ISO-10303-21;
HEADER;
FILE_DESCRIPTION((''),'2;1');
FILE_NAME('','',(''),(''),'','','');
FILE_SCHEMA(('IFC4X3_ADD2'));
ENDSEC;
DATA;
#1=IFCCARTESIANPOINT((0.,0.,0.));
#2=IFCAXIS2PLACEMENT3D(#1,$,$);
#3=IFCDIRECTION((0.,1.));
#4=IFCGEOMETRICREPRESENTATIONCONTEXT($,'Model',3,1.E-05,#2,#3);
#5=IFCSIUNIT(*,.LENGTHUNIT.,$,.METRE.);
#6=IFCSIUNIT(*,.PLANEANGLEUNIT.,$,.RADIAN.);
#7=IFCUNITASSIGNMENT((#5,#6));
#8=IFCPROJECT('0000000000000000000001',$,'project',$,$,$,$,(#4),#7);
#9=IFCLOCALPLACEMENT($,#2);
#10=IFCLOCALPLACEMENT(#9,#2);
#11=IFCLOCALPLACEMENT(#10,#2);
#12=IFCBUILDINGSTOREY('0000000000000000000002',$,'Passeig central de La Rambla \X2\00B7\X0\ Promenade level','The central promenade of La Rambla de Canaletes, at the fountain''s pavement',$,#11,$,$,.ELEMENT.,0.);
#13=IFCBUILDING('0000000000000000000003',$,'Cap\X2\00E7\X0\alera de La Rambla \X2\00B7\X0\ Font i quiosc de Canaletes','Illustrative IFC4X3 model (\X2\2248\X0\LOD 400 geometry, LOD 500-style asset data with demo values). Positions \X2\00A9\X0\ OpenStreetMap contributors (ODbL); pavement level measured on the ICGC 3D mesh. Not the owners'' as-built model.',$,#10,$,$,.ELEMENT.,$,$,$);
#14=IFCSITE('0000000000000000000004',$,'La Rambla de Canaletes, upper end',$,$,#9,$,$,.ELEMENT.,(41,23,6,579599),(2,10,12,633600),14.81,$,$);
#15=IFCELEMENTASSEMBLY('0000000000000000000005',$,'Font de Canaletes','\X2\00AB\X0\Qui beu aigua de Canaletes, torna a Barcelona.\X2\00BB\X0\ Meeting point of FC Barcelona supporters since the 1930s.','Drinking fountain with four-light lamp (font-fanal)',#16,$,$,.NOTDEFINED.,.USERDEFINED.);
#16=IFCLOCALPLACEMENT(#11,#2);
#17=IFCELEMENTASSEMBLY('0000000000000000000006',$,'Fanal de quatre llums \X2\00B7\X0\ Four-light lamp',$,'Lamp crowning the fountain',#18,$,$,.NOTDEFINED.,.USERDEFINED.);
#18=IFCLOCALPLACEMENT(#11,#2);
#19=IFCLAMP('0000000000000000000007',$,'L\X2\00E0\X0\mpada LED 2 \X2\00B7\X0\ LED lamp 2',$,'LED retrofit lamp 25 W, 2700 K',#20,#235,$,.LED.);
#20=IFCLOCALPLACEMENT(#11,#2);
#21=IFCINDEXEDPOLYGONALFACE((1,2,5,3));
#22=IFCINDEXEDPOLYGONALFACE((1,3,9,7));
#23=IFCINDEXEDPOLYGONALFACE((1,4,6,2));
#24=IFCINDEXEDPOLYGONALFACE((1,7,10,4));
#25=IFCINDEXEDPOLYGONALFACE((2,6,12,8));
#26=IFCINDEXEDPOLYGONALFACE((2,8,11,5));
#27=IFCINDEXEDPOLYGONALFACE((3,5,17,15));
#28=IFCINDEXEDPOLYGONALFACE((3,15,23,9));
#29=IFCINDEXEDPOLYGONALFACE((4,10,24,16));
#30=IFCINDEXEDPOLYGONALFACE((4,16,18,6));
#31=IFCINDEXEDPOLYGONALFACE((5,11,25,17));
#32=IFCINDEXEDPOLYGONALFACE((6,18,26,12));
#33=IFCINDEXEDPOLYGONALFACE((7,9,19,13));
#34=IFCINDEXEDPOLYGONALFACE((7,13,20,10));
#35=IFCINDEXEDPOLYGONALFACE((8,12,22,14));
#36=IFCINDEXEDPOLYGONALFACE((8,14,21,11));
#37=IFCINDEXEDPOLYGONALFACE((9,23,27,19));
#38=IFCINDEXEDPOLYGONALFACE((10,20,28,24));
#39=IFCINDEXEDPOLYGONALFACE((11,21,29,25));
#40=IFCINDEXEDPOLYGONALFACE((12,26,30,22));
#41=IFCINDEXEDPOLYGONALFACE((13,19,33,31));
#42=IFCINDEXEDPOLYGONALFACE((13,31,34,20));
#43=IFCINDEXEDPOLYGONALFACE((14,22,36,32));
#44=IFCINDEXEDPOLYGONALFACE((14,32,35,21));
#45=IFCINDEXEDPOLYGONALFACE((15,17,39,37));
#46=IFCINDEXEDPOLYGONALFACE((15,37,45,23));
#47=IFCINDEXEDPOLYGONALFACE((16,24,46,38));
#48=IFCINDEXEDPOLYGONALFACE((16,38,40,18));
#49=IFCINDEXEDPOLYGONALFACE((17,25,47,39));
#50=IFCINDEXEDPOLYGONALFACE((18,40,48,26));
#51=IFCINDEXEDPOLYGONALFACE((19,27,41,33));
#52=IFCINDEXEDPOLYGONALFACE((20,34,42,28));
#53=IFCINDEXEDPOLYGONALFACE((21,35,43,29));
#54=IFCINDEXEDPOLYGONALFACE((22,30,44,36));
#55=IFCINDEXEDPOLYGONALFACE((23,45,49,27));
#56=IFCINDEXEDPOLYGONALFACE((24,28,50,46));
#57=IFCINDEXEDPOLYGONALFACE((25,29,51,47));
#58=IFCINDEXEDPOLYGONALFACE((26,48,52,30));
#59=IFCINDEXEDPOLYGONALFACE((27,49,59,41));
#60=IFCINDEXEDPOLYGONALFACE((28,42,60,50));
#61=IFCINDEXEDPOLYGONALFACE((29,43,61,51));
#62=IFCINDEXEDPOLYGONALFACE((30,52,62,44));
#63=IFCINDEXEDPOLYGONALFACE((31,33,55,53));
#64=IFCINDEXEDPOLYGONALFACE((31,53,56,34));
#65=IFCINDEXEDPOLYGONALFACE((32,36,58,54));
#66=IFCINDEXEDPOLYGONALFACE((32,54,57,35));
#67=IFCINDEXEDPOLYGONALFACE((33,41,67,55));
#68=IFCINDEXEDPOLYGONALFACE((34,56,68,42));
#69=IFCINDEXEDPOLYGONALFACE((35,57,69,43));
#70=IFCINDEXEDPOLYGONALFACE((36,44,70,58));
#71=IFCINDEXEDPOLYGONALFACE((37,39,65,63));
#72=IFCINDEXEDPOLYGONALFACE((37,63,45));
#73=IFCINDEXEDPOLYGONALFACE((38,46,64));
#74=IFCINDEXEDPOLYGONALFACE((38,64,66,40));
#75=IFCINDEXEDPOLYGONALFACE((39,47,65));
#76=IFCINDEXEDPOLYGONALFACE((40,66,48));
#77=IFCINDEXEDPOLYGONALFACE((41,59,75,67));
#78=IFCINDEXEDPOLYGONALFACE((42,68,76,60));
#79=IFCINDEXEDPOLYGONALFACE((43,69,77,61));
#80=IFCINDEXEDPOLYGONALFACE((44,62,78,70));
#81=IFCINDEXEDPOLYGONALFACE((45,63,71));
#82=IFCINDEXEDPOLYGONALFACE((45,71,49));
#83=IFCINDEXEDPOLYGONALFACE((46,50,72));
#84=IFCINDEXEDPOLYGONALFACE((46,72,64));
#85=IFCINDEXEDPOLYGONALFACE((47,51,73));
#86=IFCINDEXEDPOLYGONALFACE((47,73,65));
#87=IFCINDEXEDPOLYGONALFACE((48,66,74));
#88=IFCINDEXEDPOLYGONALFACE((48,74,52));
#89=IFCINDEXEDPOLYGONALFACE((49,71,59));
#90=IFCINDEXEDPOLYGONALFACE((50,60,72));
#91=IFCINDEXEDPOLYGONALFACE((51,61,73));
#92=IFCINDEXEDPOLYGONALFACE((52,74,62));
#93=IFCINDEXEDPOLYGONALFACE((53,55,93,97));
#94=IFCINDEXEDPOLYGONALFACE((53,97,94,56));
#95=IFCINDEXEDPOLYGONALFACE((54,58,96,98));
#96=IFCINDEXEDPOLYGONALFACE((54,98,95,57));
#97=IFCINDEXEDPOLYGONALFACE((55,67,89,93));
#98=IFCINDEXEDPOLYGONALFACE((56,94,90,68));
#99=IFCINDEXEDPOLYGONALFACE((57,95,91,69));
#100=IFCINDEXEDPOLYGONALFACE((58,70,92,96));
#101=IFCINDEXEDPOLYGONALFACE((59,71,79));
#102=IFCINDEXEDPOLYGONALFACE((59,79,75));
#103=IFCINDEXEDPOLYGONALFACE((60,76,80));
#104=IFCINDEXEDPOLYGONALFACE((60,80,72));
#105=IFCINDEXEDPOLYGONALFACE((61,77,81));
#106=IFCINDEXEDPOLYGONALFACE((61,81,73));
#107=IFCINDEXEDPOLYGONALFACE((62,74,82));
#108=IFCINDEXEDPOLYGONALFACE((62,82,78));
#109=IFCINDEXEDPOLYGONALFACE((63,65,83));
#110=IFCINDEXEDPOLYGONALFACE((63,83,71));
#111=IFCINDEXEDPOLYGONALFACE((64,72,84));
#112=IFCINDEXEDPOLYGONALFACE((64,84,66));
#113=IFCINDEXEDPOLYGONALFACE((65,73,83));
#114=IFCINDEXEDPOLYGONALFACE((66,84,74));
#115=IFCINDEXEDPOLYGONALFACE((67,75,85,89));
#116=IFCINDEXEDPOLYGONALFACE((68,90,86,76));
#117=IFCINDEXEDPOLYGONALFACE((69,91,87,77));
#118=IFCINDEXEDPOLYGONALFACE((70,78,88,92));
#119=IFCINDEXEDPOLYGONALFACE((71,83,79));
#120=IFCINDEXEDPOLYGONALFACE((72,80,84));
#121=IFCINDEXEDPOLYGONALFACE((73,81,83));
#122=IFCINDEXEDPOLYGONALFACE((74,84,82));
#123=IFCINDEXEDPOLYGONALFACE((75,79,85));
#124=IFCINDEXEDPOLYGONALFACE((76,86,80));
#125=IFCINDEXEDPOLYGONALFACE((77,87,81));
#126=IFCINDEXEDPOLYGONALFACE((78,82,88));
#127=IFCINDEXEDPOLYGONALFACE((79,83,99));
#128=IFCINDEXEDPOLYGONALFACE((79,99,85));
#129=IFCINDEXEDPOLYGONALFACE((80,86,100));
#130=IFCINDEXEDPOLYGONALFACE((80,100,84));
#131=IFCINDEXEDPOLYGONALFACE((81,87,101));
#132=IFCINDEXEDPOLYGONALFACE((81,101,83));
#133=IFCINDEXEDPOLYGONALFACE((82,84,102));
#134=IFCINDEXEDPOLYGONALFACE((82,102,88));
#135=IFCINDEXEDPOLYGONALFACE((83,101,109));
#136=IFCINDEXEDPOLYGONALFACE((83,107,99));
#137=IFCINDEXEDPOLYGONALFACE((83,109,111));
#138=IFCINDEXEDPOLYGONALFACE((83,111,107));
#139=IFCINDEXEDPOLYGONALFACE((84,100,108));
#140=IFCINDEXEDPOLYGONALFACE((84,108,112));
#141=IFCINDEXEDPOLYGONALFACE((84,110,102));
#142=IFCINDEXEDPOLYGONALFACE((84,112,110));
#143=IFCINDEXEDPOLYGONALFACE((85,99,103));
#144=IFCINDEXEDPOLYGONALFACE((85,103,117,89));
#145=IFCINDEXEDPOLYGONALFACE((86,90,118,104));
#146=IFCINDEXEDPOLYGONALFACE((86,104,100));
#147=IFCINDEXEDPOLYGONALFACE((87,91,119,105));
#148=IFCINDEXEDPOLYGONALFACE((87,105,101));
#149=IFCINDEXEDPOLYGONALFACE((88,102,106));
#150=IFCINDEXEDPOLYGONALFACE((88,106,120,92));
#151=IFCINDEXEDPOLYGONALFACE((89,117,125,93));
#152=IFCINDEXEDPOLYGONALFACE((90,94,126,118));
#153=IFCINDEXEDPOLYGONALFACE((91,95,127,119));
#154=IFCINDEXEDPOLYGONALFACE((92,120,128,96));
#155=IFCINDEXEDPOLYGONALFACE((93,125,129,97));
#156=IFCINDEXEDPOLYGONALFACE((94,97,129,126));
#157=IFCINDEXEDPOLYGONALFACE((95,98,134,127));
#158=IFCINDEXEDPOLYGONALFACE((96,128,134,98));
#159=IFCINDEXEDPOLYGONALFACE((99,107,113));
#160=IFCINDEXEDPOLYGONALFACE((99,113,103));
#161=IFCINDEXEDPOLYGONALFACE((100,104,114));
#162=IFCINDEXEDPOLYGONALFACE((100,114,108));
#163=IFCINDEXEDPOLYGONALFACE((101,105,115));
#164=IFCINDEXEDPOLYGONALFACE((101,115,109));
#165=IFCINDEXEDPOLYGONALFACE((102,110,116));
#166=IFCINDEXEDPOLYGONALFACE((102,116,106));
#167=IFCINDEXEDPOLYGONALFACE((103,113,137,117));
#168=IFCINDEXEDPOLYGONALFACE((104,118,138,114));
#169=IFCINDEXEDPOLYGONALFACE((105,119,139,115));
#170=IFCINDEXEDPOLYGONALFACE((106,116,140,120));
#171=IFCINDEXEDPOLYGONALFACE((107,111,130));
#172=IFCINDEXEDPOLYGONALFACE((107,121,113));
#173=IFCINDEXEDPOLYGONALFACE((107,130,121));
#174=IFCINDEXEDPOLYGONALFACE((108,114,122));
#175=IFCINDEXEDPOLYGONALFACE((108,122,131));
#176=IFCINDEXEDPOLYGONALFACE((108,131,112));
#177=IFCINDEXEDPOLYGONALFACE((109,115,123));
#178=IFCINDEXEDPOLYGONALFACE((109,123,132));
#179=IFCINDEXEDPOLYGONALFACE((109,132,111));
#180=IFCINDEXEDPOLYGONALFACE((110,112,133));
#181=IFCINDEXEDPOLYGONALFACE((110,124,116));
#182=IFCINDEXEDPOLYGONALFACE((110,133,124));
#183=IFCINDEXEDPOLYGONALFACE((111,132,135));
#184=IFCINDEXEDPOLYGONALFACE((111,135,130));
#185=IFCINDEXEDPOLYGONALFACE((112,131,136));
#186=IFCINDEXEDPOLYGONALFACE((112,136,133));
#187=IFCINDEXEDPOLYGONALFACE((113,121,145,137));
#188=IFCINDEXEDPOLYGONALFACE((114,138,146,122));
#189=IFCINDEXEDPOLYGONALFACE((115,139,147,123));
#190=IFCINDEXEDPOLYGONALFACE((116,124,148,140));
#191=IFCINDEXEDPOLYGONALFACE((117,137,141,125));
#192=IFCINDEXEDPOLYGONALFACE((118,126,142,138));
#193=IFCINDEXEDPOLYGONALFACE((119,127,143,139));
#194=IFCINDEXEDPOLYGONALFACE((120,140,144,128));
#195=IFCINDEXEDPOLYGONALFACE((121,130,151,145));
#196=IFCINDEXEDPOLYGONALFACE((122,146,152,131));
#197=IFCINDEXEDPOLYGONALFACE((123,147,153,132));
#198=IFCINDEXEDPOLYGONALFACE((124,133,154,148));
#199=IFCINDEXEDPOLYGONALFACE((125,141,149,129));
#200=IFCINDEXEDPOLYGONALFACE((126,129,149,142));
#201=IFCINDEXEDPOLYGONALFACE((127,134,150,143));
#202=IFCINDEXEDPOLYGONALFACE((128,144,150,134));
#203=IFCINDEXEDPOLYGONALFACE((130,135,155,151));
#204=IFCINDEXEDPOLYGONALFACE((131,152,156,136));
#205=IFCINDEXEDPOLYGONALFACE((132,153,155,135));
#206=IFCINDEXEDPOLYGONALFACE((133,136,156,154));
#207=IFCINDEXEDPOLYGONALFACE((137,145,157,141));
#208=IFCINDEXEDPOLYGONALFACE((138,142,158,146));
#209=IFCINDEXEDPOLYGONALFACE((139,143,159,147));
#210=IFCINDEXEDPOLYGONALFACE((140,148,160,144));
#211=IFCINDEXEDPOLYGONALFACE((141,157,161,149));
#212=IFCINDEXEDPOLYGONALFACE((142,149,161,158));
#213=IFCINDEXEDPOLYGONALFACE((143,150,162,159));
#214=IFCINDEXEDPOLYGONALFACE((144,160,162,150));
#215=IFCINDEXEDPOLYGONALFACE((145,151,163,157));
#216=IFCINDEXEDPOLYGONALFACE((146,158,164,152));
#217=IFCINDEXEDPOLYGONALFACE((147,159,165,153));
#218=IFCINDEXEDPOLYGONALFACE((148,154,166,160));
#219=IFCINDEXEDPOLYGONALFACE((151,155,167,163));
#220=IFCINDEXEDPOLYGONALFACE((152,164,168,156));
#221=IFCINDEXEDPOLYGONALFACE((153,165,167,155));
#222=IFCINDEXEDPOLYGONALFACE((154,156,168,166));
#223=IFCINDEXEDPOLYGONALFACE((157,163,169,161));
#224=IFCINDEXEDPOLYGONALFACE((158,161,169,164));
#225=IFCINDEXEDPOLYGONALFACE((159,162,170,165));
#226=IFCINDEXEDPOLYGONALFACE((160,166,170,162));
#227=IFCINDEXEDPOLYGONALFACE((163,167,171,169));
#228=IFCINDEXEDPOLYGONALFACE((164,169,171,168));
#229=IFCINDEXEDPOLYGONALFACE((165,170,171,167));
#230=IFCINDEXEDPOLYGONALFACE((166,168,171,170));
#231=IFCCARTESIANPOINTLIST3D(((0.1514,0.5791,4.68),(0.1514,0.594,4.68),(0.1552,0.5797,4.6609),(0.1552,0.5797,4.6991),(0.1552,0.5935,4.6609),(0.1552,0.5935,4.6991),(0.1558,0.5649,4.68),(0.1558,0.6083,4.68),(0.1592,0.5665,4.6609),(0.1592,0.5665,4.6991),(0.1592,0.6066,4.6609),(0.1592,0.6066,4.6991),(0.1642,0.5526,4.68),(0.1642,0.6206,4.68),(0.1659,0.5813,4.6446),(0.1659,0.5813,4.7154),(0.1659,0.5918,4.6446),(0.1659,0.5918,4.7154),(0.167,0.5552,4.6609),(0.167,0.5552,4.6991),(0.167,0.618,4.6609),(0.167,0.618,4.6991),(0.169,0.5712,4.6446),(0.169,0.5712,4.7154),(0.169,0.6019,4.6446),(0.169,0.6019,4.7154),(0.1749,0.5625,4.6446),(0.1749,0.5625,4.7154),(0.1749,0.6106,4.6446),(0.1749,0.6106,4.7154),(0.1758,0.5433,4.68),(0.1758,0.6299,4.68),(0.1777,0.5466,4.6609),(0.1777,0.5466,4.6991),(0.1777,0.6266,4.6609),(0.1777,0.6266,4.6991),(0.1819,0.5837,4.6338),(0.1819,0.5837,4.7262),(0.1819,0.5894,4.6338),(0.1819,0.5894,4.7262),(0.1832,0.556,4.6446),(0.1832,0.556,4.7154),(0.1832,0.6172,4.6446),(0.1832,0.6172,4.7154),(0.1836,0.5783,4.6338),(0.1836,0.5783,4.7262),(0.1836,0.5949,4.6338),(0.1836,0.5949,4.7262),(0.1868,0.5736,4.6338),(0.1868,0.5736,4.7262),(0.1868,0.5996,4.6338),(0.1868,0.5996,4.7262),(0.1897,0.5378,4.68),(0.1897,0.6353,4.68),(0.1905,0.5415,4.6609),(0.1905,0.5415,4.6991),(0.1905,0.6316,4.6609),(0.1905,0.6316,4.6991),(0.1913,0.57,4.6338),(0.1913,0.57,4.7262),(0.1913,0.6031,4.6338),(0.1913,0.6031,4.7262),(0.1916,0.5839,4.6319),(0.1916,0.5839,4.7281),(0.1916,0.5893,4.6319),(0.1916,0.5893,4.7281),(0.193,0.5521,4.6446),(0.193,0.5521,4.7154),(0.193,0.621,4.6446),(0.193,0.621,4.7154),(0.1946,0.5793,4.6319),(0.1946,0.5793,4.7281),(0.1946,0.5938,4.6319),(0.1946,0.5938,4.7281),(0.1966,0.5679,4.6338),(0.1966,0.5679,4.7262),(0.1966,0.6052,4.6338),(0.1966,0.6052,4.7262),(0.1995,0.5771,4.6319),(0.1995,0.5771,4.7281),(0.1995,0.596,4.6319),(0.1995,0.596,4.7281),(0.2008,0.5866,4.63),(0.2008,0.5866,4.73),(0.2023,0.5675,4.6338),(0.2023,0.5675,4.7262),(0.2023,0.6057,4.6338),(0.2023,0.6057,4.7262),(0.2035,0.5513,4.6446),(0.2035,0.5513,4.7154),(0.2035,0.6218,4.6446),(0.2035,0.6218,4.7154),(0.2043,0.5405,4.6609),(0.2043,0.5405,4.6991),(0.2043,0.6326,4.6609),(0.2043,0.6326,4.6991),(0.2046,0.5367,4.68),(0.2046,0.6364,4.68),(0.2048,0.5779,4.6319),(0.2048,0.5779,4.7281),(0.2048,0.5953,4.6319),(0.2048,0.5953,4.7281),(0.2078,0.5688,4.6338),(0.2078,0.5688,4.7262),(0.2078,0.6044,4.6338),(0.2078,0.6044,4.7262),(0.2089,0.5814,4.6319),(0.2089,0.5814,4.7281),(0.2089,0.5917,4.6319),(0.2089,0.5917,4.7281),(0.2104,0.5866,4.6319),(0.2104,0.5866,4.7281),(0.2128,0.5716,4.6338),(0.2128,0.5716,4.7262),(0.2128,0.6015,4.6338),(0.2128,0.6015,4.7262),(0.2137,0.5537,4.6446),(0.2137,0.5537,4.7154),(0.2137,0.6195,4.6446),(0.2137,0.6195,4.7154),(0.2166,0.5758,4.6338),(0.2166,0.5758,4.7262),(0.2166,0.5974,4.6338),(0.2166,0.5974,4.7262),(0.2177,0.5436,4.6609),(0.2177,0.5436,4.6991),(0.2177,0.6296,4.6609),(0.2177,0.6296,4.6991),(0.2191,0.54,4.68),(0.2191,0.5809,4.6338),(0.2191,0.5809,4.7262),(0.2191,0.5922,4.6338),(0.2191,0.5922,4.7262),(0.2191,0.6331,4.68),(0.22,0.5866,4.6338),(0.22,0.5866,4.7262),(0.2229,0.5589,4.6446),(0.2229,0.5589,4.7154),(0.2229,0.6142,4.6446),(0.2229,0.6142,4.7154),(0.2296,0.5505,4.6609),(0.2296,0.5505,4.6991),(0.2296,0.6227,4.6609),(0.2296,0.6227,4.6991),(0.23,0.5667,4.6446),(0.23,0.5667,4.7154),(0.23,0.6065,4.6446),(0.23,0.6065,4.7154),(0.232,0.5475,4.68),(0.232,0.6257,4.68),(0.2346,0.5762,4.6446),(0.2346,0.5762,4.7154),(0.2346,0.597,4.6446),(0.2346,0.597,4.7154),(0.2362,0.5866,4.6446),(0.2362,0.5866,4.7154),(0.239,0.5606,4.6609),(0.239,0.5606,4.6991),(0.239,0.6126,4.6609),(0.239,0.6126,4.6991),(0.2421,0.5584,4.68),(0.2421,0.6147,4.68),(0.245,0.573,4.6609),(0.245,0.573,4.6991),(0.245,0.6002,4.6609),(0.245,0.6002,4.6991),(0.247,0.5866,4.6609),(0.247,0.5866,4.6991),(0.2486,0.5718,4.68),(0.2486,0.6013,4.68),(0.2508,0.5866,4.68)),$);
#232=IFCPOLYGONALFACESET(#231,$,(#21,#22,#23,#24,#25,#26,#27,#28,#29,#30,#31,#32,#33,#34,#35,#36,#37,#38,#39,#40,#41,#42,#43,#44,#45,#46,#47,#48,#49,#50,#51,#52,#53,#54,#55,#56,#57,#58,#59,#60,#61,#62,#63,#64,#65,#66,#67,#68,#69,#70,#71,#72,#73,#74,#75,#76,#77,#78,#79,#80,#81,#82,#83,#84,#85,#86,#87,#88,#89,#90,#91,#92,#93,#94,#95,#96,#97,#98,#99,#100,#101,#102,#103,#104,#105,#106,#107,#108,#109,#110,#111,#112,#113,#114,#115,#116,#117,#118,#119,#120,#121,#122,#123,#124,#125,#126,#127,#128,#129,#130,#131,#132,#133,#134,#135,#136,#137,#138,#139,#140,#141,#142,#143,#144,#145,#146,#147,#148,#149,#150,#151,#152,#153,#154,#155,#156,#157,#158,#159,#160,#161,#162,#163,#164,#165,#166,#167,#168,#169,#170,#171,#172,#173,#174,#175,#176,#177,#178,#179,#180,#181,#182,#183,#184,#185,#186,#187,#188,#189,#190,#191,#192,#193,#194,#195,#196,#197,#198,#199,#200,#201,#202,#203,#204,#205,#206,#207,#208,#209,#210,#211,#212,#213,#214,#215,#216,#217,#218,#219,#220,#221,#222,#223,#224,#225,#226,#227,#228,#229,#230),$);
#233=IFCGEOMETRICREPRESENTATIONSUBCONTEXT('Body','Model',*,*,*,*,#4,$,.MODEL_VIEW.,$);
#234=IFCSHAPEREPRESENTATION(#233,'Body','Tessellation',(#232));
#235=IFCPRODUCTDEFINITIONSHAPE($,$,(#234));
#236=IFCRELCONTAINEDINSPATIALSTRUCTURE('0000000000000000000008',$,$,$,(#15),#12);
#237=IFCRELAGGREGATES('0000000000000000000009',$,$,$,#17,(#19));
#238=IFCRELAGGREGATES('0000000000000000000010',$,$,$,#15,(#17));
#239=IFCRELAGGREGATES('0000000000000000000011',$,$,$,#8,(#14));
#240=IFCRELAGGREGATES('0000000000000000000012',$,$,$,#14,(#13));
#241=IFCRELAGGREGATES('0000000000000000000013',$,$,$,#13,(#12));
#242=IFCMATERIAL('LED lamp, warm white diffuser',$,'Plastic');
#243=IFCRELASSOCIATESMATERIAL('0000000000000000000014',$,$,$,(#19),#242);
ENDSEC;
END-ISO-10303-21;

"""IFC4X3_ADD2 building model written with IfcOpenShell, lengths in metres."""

from ifc_helpers import new_model, entity, si_unit, direction, origin, place, context, subcontext, project, spatial, material, element, aggregate, save


model = new_model("IFC4X3_ADD2")

# Units and contexts
model_context = context("Model", 3, precision=1e-05, world=origin(), true_north=direction((0.0, 1.0)))
body_context = subcontext(model_context, "Body", "Model", "MODEL_VIEW")
ifc_project = project(units=[si_unit("LENGTHUNIT", "METRE"), si_unit("PLANEANGLEUNIT", "RADIAN")], contexts=[model_context])

# Site, building, storey
site_placement = place(None, origin())
site = spatial("IfcSite", under=ifc_project, at=site_placement, Name="La Rambla de Canaletes, upper end", CompositionType="ELEMENT", RefLatitude=(41, 23, 6, 579599), RefLongitude=(2, 10, 12, 633600), RefElevation=14.81)
building_placement = place(site_placement, origin())
building = spatial("IfcBuilding", under=site, at=building_placement, Name="Capçalera de La Rambla · Font i quiosc de Canaletes", Description="Illustrative IFC4X3 model (≈LOD 400 geometry, LOD 500-style asset data with demo values). Positions © OpenStreetMap contributors (ODbL); pavement level measured on the ICGC 3D mesh. Not the owners' as-built model.", CompositionType="ELEMENT")
storey_placement = place(building_placement, origin())
storey = spatial("IfcBuildingStorey", under=building, at=storey_placement, Name="Passeig central de La Rambla · Promenade level", Description="The central promenade of La Rambla de Canaletes, at the fountain's pavement", CompositionType="ELEMENT", Elevation=0.0)

# Element assemblies, lamp
assembly_1_placement = place(building_placement, origin())
assembly_1 = element("IfcElementAssembly", 1, at=assembly_1_placement, inside=storey, Name="Font de Canaletes", Description="«Qui beu aigua de Canaletes, torna a Barcelona.» Meeting point of FC Barcelona supporters since the 1930s.", ObjectType="Drinking fountain with four-light lamp (font-fanal)", AssemblyPlace="NOTDEFINED", PredefinedType="USERDEFINED")
assembly_2_placement = place(building_placement, origin())
assembly_2 = element("IfcElementAssembly", 2, at=assembly_2_placement, Name="Fanal de quatre llums · Four-light lamp", ObjectType="Lamp crowning the fountain", AssemblyPlace="NOTDEFINED", PredefinedType="USERDEFINED")
ifc_material_1 = material(Name="LED lamp, warm white diffuser", Category="Plastic")
lamp_1_placement = place(building_placement, origin())
lamp_1 = element("IfcLamp", 3, at=lamp_1_placement, material=ifc_material_1, Name="Làmpada LED 2 · LED lamp 2", ObjectType="LED retrofit lamp 25 W, 2700 K", PredefinedType="LED", context=body_context, shape_type="SweptSolid", body=[
    entity("IfcRevolvedAreaSolid", entity("IfcArbitraryClosedProfileDef", "AREA", None, entity("IfcPolyline", [entity("IfcCartesianPoint", [0.0, -0.05]), entity("IfcCartesianPoint", [0.0191, -0.0462]), entity("IfcCartesianPoint", [0.0354, -0.0354]), entity("IfcCartesianPoint", [0.0462, -0.0191]), entity("IfcCartesianPoint", [0.05, 0.0]), entity("IfcCartesianPoint", [0.0462, 0.0191]), entity("IfcCartesianPoint", [0.0354, 0.0354]), entity("IfcCartesianPoint", [0.0191, 0.0462]), entity("IfcCartesianPoint", [0.0, 0.05]), entity("IfcCartesianPoint", [0.0, -0.05])])), entity("IfcAxis2Placement3D", entity("IfcCartesianPoint", [0.2008, 0.5866, 4.68]), entity("IfcDirection", [0.0, -1.0, 0.0]), entity("IfcDirection", [1.0, 0.0, 0.0])), entity("IfcAxis1Placement", entity("IfcCartesianPoint", [0.0, 0.0, 0.0]), entity("IfcDirection", [0.0, 1.0, 0.0])), 6.283185),
])
aggregate(assembly_2, [lamp_1])
aggregate(assembly_1, [assembly_2])

save(model, "model.ifc")
